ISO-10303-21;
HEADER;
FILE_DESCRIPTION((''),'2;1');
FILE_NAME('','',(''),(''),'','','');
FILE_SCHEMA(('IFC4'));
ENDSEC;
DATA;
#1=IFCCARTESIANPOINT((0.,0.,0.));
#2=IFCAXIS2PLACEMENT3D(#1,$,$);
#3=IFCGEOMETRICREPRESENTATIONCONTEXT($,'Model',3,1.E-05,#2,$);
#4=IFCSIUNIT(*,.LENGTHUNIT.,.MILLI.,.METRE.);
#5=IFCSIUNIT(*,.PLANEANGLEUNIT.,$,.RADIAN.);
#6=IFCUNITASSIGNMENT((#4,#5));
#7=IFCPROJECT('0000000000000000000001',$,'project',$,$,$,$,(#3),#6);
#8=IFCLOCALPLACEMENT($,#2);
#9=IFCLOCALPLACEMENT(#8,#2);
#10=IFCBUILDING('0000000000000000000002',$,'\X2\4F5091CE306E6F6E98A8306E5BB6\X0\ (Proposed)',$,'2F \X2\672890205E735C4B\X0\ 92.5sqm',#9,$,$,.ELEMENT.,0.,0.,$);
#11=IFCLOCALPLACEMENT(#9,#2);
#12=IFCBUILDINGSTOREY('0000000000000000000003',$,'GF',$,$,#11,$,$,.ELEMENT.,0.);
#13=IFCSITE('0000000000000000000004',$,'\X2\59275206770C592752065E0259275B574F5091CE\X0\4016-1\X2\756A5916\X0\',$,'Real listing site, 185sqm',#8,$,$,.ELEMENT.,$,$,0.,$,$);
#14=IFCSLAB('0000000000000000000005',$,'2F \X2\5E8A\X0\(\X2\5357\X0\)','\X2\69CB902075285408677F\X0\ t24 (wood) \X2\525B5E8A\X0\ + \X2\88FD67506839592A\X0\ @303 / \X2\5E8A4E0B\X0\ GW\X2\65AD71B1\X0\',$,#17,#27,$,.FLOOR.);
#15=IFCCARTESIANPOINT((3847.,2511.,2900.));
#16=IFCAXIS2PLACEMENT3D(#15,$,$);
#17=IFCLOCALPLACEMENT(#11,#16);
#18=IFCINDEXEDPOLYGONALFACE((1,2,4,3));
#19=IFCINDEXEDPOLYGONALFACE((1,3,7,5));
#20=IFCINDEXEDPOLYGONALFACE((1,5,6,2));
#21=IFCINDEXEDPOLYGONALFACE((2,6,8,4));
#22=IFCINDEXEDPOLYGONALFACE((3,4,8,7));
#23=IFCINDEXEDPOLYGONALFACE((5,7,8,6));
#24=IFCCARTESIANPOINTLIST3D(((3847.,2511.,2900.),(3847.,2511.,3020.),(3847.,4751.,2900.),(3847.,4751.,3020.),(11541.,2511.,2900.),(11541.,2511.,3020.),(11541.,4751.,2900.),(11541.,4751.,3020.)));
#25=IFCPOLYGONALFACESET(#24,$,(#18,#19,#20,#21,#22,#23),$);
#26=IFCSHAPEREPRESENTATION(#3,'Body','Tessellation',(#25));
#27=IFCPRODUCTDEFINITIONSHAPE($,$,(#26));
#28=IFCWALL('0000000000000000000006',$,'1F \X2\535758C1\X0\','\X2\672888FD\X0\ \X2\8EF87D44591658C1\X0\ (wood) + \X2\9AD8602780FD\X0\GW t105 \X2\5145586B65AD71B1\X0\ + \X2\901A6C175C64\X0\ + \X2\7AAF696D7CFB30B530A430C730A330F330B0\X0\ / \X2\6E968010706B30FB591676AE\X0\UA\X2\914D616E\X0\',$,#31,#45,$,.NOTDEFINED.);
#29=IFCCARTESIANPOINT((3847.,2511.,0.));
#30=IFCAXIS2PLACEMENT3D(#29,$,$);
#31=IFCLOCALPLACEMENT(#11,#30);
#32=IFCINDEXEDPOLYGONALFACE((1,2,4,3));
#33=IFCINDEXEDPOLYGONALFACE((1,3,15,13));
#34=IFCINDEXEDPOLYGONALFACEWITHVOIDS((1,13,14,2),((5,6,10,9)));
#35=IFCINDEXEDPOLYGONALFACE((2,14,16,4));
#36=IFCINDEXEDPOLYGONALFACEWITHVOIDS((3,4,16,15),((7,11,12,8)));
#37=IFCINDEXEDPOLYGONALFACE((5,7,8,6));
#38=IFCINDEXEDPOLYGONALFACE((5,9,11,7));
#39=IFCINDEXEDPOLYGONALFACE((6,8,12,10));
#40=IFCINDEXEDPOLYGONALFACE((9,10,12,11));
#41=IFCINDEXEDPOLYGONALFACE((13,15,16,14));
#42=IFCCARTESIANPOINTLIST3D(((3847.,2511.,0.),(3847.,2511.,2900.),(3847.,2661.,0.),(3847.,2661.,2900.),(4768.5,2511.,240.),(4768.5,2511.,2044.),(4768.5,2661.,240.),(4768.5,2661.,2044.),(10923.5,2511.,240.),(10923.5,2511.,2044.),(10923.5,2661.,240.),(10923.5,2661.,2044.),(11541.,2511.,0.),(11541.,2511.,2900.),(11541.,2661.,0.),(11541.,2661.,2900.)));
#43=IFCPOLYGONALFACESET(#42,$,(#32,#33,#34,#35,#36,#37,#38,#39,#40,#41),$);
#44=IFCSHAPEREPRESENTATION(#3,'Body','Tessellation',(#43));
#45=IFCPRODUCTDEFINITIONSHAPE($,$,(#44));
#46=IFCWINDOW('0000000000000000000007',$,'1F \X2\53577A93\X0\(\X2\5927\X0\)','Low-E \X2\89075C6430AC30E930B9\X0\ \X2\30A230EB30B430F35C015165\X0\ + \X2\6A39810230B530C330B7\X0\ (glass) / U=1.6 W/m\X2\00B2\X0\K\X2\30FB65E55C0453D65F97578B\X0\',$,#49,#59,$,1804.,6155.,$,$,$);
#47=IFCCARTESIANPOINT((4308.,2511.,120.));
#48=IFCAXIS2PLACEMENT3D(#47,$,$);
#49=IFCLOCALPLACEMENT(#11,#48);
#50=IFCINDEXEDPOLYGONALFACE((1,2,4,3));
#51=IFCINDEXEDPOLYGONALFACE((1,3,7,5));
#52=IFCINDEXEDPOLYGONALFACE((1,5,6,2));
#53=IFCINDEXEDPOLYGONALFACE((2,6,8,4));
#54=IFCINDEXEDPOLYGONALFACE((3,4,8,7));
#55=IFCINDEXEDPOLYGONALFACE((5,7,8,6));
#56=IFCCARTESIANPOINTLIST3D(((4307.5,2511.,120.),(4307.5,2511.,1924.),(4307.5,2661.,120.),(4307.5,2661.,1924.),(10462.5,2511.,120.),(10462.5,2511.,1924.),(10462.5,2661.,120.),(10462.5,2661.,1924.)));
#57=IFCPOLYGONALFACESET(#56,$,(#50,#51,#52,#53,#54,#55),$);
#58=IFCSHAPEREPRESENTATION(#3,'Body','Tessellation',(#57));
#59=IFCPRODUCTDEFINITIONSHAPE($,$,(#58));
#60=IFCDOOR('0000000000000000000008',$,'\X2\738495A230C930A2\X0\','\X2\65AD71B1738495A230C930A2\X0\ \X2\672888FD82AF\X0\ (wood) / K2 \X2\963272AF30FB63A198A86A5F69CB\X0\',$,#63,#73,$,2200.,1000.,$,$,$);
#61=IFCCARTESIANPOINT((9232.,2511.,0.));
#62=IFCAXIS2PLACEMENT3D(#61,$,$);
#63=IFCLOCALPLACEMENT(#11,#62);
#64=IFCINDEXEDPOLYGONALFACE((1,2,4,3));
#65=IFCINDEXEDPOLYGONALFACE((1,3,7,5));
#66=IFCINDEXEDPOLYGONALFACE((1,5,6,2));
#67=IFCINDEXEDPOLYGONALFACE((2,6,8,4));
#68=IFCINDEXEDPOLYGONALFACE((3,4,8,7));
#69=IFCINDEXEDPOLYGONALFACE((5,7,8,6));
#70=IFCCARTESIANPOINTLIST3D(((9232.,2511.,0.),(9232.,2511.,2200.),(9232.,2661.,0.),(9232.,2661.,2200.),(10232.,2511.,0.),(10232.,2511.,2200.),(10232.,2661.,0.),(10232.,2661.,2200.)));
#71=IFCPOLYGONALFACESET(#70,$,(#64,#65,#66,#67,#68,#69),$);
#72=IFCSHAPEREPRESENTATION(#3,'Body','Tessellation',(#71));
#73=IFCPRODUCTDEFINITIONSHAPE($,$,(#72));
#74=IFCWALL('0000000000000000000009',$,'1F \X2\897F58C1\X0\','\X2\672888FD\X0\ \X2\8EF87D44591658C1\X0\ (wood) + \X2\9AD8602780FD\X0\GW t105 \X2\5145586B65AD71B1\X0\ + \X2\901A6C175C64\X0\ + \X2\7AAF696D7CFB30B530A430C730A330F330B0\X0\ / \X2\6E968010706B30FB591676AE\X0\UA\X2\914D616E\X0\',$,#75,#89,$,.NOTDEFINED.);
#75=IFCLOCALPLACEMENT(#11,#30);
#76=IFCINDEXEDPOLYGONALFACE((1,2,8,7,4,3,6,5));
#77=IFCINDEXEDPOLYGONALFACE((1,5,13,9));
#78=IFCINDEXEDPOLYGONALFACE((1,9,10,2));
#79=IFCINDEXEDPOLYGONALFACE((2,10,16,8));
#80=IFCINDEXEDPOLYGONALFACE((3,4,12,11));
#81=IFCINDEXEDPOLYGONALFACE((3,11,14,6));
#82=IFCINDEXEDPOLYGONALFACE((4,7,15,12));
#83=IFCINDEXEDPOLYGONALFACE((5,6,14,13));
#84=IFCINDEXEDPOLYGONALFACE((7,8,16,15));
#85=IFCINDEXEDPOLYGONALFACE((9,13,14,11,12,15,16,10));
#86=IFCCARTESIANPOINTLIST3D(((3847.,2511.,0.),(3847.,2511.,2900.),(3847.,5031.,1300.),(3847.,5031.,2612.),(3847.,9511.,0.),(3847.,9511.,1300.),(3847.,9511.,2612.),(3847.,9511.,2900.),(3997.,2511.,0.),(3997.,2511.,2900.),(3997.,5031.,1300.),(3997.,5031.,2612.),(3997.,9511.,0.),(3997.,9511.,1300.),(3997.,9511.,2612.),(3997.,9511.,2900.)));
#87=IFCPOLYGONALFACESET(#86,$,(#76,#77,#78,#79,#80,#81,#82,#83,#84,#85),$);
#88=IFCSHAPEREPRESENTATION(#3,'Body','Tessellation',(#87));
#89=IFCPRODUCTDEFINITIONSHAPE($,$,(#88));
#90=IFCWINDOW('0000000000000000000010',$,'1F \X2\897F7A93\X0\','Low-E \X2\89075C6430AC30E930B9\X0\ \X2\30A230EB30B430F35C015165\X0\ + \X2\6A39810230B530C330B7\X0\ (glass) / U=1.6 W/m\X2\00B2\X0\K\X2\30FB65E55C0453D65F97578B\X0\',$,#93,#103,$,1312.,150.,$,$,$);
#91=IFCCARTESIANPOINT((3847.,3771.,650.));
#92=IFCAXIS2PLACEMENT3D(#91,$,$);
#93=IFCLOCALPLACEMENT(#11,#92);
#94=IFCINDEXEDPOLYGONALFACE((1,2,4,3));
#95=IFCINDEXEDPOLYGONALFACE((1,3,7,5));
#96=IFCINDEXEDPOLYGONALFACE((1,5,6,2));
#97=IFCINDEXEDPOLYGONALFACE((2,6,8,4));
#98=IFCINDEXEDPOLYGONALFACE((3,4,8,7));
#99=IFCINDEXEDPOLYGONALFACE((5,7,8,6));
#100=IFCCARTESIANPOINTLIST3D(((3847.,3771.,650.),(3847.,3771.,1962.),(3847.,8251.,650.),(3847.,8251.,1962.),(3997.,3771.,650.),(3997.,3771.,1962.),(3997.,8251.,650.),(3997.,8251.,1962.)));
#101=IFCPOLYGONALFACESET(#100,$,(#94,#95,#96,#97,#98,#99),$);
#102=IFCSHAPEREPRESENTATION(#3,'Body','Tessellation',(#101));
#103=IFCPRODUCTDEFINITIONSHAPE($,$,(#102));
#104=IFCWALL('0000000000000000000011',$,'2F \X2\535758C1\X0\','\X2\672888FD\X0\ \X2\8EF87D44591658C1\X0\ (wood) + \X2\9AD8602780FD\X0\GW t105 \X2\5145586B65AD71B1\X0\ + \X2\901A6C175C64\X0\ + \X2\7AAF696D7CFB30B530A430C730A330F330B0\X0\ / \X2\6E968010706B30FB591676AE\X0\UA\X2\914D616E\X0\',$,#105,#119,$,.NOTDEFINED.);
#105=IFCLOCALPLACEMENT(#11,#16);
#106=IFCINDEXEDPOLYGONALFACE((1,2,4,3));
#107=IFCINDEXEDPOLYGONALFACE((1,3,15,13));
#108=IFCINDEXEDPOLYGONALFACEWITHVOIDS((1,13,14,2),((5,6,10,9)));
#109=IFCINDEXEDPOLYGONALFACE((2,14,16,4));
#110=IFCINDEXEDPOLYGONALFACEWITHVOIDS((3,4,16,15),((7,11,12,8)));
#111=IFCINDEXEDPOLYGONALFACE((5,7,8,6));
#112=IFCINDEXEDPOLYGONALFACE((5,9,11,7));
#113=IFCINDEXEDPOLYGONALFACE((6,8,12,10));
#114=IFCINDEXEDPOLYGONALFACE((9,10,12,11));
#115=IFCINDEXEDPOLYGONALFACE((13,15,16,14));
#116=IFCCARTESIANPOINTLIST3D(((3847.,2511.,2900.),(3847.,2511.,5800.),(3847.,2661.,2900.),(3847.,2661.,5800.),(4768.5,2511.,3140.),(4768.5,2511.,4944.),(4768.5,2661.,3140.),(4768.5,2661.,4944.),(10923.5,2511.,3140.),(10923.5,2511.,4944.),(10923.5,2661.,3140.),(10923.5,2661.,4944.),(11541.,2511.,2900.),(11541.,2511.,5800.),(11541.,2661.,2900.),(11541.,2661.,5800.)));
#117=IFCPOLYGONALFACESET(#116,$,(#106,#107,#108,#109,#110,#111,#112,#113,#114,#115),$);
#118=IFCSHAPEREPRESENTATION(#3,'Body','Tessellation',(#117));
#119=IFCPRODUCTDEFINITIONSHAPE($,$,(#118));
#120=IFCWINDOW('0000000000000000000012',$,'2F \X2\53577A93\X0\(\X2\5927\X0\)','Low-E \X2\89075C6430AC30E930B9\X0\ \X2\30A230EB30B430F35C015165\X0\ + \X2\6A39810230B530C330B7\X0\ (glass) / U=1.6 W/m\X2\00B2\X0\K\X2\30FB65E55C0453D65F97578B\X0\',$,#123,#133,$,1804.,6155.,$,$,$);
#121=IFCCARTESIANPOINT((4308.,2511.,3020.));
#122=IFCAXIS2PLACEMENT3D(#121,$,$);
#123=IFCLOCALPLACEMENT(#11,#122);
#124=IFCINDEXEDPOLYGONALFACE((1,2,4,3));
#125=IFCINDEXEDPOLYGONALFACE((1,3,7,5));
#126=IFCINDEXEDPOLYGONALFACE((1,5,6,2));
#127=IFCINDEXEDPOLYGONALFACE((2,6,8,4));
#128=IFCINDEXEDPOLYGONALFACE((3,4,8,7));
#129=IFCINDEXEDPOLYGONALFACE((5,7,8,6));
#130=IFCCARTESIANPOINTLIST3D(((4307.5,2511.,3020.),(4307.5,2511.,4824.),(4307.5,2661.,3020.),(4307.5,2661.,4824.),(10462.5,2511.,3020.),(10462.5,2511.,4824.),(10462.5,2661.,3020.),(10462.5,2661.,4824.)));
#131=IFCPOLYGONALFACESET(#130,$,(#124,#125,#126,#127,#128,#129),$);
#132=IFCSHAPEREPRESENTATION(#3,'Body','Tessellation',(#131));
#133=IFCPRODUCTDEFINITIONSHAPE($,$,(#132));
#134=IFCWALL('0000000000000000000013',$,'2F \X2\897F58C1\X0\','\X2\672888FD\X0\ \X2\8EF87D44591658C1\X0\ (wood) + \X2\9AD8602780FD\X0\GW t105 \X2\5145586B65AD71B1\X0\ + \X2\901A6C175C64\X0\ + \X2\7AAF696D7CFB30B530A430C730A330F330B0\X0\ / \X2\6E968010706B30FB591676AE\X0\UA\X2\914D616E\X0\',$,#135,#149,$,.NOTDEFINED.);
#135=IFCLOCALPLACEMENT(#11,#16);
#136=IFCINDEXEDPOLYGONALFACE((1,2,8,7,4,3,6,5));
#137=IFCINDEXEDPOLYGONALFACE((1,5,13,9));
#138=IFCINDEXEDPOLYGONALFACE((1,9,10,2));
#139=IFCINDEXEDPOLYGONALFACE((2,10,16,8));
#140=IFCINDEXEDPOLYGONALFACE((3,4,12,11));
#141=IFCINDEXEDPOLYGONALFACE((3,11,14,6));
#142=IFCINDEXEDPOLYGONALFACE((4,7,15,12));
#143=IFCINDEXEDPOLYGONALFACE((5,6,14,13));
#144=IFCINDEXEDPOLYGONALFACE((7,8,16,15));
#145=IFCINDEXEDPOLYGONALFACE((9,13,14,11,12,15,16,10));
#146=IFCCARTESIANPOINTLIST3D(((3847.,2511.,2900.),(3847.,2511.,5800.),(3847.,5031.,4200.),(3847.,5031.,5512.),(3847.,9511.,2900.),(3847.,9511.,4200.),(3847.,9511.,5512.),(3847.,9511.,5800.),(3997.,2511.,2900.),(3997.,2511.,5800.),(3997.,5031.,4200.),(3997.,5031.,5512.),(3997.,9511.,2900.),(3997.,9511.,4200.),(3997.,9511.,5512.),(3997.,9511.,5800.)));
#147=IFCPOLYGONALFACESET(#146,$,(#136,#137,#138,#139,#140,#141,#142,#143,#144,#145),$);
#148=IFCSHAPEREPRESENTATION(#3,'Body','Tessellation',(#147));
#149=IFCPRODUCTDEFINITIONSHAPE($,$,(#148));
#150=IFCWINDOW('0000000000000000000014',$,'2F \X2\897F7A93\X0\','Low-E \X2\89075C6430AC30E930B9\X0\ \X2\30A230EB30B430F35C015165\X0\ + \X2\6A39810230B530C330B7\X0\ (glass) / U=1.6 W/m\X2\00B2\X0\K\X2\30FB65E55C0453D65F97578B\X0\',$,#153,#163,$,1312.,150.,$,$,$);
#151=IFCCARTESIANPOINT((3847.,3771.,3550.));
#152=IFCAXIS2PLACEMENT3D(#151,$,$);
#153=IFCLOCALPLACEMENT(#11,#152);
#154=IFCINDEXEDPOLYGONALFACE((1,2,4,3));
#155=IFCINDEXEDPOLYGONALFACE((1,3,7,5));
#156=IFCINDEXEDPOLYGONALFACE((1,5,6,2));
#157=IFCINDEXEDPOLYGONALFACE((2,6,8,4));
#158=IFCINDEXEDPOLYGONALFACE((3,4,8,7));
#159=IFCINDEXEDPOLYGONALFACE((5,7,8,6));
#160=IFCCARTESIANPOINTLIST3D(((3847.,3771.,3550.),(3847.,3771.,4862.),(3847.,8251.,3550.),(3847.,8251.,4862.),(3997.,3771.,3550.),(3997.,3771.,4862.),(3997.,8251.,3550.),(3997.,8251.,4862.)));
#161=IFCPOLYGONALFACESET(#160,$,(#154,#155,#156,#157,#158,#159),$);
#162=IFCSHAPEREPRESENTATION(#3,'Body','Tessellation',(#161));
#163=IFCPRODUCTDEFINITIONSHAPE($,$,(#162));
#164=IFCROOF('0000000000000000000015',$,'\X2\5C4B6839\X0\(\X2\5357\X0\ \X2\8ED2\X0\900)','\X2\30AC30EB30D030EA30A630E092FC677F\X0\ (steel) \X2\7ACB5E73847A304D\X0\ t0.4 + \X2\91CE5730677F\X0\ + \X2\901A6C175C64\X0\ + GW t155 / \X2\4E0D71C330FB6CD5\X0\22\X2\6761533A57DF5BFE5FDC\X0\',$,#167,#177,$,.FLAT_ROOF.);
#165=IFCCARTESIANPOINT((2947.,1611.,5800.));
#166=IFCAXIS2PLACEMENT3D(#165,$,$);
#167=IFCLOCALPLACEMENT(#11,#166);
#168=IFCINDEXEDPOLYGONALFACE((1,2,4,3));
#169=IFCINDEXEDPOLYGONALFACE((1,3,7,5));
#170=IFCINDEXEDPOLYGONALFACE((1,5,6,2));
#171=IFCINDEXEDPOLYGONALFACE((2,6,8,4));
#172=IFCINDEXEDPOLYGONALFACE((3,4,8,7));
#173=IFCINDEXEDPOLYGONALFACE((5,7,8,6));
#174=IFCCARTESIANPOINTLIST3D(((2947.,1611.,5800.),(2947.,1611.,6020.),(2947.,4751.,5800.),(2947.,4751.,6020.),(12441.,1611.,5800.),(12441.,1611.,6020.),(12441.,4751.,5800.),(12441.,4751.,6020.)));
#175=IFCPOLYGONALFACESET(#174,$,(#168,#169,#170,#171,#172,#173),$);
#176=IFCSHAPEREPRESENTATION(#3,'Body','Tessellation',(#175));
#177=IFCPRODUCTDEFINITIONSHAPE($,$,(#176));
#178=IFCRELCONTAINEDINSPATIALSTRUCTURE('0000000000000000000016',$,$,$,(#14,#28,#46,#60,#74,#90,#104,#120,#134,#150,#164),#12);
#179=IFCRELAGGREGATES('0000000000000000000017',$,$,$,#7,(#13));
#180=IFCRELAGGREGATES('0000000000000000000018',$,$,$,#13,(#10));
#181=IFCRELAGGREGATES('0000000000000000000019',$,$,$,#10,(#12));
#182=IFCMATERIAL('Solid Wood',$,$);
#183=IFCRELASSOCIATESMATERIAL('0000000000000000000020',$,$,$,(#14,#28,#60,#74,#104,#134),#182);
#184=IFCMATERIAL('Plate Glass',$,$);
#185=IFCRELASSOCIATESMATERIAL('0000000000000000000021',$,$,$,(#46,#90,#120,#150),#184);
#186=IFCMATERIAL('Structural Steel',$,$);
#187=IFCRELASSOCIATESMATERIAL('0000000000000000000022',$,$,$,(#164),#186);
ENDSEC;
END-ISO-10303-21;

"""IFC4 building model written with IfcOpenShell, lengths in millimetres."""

from ifc_helpers import new_model, si_unit, frame, frame_2d, origin, place, context, project, spatial, rectangle, extrude, material, element, fill, save


model = new_model("IFC4")

# Units and contexts
model_context = context("Model", 3, precision=1e-05, world=origin())
ifc_project = project(units=[si_unit("LENGTHUNIT", "METRE", prefix="MILLI"), si_unit("PLANEANGLEUNIT", "RADIAN")], contexts=[model_context])

# Site, building, storey
site_placement = place(None, origin())
site = spatial("IfcSite", under=ifc_project, at=site_placement, Name="大分県大分市大字佐野4016-1番外", ObjectType="Real listing site, 185sqm", CompositionType="ELEMENT", RefElevation=0.0)
building_placement = place(site_placement, origin())
building = spatial("IfcBuilding", under=site, at=building_placement, Name="佐野の潮風の家 (Proposed)", ObjectType="2F 木造平屋 92.5sqm", CompositionType="ELEMENT", ElevationOfRefHeight=0.0, ElevationOfTerrain=0.0)
storey_placement = place(building_placement, origin())
storey = spatial("IfcBuildingStorey", under=building, at=storey_placement, Name="GF", CompositionType="ELEMENT", Elevation=0.0)

# Slab
ifc_material_1 = material(Name="Solid Wood")
slab_1_placement = place(storey_placement, frame((3847.0, 2511.0, 2900.0)))
element("IfcSlab", 1, at=slab_1_placement, inside=storey, material=ifc_material_1, Name="2F 床(南)", Description="構造用合板 t24 (wood) 剛床 + 製材根太 @303 / 床下 GW断熱", PredefinedType="FLOOR", context=model_context, shape_type="SweptSolid", body=[
    extrude(rectangle(XDim=7694.0, YDim=2240.0, at=frame_2d((3847.0, 1120.0))), frame((3847.0, 2511.0, 2900.0)), (0.0, 0.0, 1.0), 120.0),
])

# Wall, openings, window, door
wall_1_placement = place(storey_placement, frame((3847.0, 2511.0, 0.0)))
wall_1 = element("IfcWall", 2, at=wall_1_placement, inside=storey, material=ifc_material_1, Name="1F 南壁", Description="木製 軸組外壁 (wood) + 高性能GW t105 充填断熱 + 通気層 + 窯業系サイディング / 準耐火・外皮UA配慮", PredefinedType="NOTDEFINED", context=model_context, shape_type="SweptSolid", body=[
    extrude(rectangle(XDim=7694.0, YDim=150.0, at=frame_2d((3847.0, 75.0))), frame((3847.0, 2511.0, 0.0)), (0.0, 0.0, 1.0), 2900.0),
])
opening_1_placement = place(storey_placement, frame((4308.0, 2511.0, 120.0)))
opening_1 = element("IfcOpeningElement", 3, at=opening_1_placement, cuts=wall_1, PredefinedType="NOTDEFINED", context=model_context, shape_type="SweptSolid", body=[
    extrude(rectangle(XDim=6155.0, YDim=150.0, at=frame_2d((3077.0, 75.0))), frame((4308.0, 2511.0, 120.0)), (0.0, 0.0, 1.0), 1804.0),
])
opening_2_placement = place(storey_placement, frame((9232.0, 2511.0, 0.0)))
opening_2 = element("IfcOpeningElement", 4, at=opening_2_placement, cuts=wall_1, PredefinedType="NOTDEFINED", context=model_context, shape_type="SweptSolid", body=[
    extrude(rectangle(XDim=1000.0, YDim=150.0, at=frame_2d((500.0, 75.0))), frame((9232.0, 2511.0, 0.0)), (0.0, 0.0, 1.0), 2200.0),
])
ifc_material_2 = material(Name="Plate Glass")
window_1_placement = place(storey_placement, frame((4308.0, 2511.0, 120.0)))
window_1 = element("IfcWindow", 5, at=window_1_placement, inside=storey, material=ifc_material_2, Name="1F 南窓(大)", Description="Low-E 複層ガラス アルゴン封入 + 樹脂サッシ (glass) / U=1.6 W/m²K・日射取得型", OverallHeight=1804.0, OverallWidth=6155.0, context=model_context, shape_type="SweptSolid", body=[
    extrude(rectangle(XDim=6155.0, YDim=150.0, at=frame_2d((3077.0, 75.0))), frame((4308.0, 2511.0, 120.0)), (0.0, 0.0, 1.0), 1804.0),
])
fill(opening_1, window_1)
door_placement = place(storey_placement, frame((9232.0, 2511.0, 0.0)))
door = element("IfcDoor", 6, at=door_placement, inside=storey, material=ifc_material_1, Name="玄関ドア", Description="断熱玄関ドア 木製芯 (wood) / K2 防犯・採風機構", OverallHeight=2200.0, OverallWidth=1000.0, context=model_context, shape_type="SweptSolid", body=[
    extrude(rectangle(XDim=1000.0, YDim=150.0, at=frame_2d((500.0, 75.0))), frame((9232.0, 2511.0, 0.0)), (0.0, 0.0, 1.0), 2200.0),
])
fill(opening_2, door)

# Walls, openings, windows
wall_2_placement = place(storey_placement, frame((3847.0, 2511.0, 0.0)))
wall_2 = element("IfcWall", 7, at=wall_2_placement, inside=storey, material=ifc_material_1, Name="1F 西壁", Description="木製 軸組外壁 (wood) + 高性能GW t105 充填断熱 + 通気層 + 窯業系サイディング / 準耐火・外皮UA配慮", PredefinedType="NOTDEFINED", context=model_context, shape_type="SweptSolid", body=[
    extrude(rectangle(XDim=150.0, YDim=7000.0, at=frame_2d((75.0, 3500.0))), frame((3847.0, 2511.0, 0.0)), (0.0, 0.0, 1.0), 2900.0),
])
opening_3_placement = place(storey_placement, frame((3847.0, 3771.0, 650.0)))
opening_3 = element("IfcOpeningElement", 8, at=opening_3_placement, cuts=wall_2, PredefinedType="NOTDEFINED", context=model_context, shape_type="SweptSolid", body=[
    extrude(rectangle(XDim=150.0, YDim=4480.0, at=frame_2d((75.0, 2240.0))), frame((3847.0, 3771.0, 650.0)), (0.0, 0.0, 1.0), 1312.0),
])
window_2_placement = place(storey_placement, frame((3847.0, 3771.0, 650.0)))
window_2 = element("IfcWindow", 9, at=window_2_placement, inside=storey, material=ifc_material_2, Name="1F 西窓", Description="Low-E 複層ガラス アルゴン封入 + 樹脂サッシ (glass) / U=1.6 W/m²K・日射取得型", OverallHeight=1312.0, OverallWidth=150.0, context=model_context, shape_type="SweptSolid", body=[
    extrude(rectangle(XDim=150.0, YDim=4480.0, at=frame_2d((75.0, 2240.0))), frame((3847.0, 3771.0, 650.0)), (0.0, 0.0, 1.0), 1312.0),
])
fill(opening_3, window_2)
wall_3_placement = place(storey_placement, frame((3847.0, 2511.0, 2900.0)))
wall_3 = element("IfcWall", 10, at=wall_3_placement, inside=storey, material=ifc_material_1, Name="2F 南壁", Description="木製 軸組外壁 (wood) + 高性能GW t105 充填断熱 + 通気層 + 窯業系サイディング / 準耐火・外皮UA配慮", PredefinedType="NOTDEFINED", context=model_context, shape_type="SweptSolid", body=[
    extrude(rectangle(XDim=7694.0, YDim=150.0, at=frame_2d((3847.0, 75.0))), frame((3847.0, 2511.0, 2900.0)), (0.0, 0.0, 1.0), 2900.0),
])
opening_4_placement = place(storey_placement, frame((4308.0, 2511.0, 3020.0)))
opening_4 = element("IfcOpeningElement", 11, at=opening_4_placement, cuts=wall_3, PredefinedType="NOTDEFINED", context=model_context, shape_type="SweptSolid", body=[
    extrude(rectangle(XDim=6155.0, YDim=150.0, at=frame_2d((3077.0, 75.0))), frame((4308.0, 2511.0, 3020.0)), (0.0, 0.0, 1.0), 1804.0),
])
window_3_placement = place(storey_placement, frame((4308.0, 2511.0, 3020.0)))
window_3 = element("IfcWindow", 12, at=window_3_placement, inside=storey, material=ifc_material_2, Name="2F 南窓(大)", Description="Low-E 複層ガラス アルゴン封入 + 樹脂サッシ (glass) / U=1.6 W/m²K・日射取得型", OverallHeight=1804.0, OverallWidth=6155.0, context=model_context, shape_type="SweptSolid", body=[
    extrude(rectangle(XDim=6155.0, YDim=150.0, at=frame_2d((3077.0, 75.0))), frame((4308.0, 2511.0, 3020.0)), (0.0, 0.0, 1.0), 1804.0),
])
fill(opening_4, window_3)
wall_4_placement = place(storey_placement, frame((3847.0, 2511.0, 2900.0)))
wall_4 = element("IfcWall", 13, at=wall_4_placement, inside=storey, material=ifc_material_1, Name="2F 西壁", Description="木製 軸組外壁 (wood) + 高性能GW t105 充填断熱 + 通気層 + 窯業系サイディング / 準耐火・外皮UA配慮", PredefinedType="NOTDEFINED", context=model_context, shape_type="SweptSolid", body=[
    extrude(rectangle(XDim=150.0, YDim=7000.0, at=frame_2d((75.0, 3500.0))), frame((3847.0, 2511.0, 2900.0)), (0.0, 0.0, 1.0), 2900.0),
])
opening_5_placement = place(storey_placement, frame((3847.0, 3771.0, 3550.0)))
opening_5 = element("IfcOpeningElement", 14, at=opening_5_placement, cuts=wall_4, PredefinedType="NOTDEFINED", context=model_context, shape_type="SweptSolid", body=[
    extrude(rectangle(XDim=150.0, YDim=4480.0, at=frame_2d((75.0, 2240.0))), frame((3847.0, 3771.0, 3550.0)), (0.0, 0.0, 1.0), 1312.0),
])
window_4_placement = place(storey_placement, frame((3847.0, 3771.0, 3550.0)))
window_4 = element("IfcWindow", 15, at=window_4_placement, inside=storey, material=ifc_material_2, Name="2F 西窓", Description="Low-E 複層ガラス アルゴン封入 + 樹脂サッシ (glass) / U=1.6 W/m²K・日射取得型", OverallHeight=1312.0, OverallWidth=150.0, context=model_context, shape_type="SweptSolid", body=[
    extrude(rectangle(XDim=150.0, YDim=4480.0, at=frame_2d((75.0, 2240.0))), frame((3847.0, 3771.0, 3550.0)), (0.0, 0.0, 1.0), 1312.0),
])
fill(opening_5, window_4)

# Roof
ifc_material_3 = material(Name="Structural Steel")
roof_1_placement = place(storey_placement, frame((2947.0, 1611.0, 5800.0)))
element("IfcRoof", 16, at=roof_1_placement, inside=storey, material=ifc_material_3, Name="屋根(南 軒900)", Description="ガルバリウム鋼板 (steel) 立平葺き t0.4 + 野地板 + 通気層 + GW t155 / 不燃・法22条区域対応", PredefinedType="FLAT_ROOF", context=model_context, shape_type="SweptSolid", body=[
    extrude(rectangle(XDim=9494.0, YDim=3140.0, at=frame_2d((4747.0, 1570.0))), frame((2947.0, 1611.0, 5800.0)), (0.0, 0.0, 1.0), 220.0),
])

save(model, "model.ifc")
